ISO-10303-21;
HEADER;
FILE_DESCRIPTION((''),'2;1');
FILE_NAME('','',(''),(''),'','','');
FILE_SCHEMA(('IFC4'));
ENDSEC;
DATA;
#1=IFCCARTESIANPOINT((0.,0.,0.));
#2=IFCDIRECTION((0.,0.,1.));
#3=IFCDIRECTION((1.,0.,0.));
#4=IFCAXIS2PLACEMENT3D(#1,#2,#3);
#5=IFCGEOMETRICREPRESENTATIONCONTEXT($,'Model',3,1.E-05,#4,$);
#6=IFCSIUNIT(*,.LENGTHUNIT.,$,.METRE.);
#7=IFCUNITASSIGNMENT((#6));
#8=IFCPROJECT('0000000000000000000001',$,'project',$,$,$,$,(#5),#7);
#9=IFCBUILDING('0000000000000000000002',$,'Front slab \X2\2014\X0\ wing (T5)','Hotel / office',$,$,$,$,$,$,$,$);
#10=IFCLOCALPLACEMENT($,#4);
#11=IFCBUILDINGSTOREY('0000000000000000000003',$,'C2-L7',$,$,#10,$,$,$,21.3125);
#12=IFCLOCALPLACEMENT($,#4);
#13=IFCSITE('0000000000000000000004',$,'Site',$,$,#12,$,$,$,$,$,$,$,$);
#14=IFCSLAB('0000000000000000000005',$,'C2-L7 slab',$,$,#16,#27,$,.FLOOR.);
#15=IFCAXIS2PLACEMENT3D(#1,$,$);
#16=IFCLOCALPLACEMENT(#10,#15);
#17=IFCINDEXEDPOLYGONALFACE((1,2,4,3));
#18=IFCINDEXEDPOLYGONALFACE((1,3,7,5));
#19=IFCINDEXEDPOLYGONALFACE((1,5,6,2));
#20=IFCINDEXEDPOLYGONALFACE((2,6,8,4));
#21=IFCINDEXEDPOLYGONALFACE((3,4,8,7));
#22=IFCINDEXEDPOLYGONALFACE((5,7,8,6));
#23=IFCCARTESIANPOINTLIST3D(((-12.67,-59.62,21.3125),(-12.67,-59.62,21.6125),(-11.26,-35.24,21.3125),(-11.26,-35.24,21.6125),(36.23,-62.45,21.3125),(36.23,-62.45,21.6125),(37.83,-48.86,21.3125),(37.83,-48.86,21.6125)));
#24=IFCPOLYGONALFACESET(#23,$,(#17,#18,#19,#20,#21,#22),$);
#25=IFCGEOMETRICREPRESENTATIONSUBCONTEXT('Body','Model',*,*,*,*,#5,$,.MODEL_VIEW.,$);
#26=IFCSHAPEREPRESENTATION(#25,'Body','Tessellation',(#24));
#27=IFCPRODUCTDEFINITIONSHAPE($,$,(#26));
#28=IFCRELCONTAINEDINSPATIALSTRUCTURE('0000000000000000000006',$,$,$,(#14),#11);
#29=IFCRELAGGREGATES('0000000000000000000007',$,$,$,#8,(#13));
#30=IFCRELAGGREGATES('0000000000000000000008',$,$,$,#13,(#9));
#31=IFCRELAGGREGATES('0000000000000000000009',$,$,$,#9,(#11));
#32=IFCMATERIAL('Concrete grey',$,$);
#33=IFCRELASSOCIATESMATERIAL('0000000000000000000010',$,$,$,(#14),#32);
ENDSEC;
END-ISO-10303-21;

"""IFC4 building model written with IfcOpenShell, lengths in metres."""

from ifc_helpers import new_model, si_unit, frame, origin_with_axes, place, context, subcontext, project, spatial, polyline, outline, extrude, material, element, save


model = new_model("IFC4")

# Units and contexts
model_context = context("Model", 3, precision=1e-05, world=origin_with_axes())
body_context = subcontext(model_context, "Body", "Model", "MODEL_VIEW")
ifc_project = project(units=[si_unit("LENGTHUNIT", "METRE")], contexts=[model_context])

# Site, building, storey
site_placement = place(None, origin_with_axes())
site = spatial("IfcSite", under=ifc_project, at=site_placement, Name="Site")
building = spatial("IfcBuilding", under=site, Name="Front slab — wing (T5)", Description="Hotel / office")
storey_placement = place(None, origin_with_axes())
storey = spatial("IfcBuildingStorey", under=building, at=storey_placement, Name="C2-L7", Elevation=21.3125)

# Slab
ifc_material_1 = material(Name="Concrete grey")
slab_placement = place(storey_placement, origin_with_axes())
element("IfcSlab", 1, at=slab_placement, inside=storey, material=ifc_material_1, Name="C2-L7 slab", PredefinedType="FLOOR", context=body_context, shape_type="SweptSolid", body=[
    extrude(outline(polyline([(-11.26, -35.24), (-12.67, -59.62), (36.23, -62.45), (37.83, -48.86), (-11.26, -35.24)])), frame((0.0, 0.0, 21.3125), z_axis=(0.0, 0.0, 1.0), x_axis=(1.0, 0.0, 0.0)), (0.0, 0.0, 1.0), 0.3),
])

save(model, "model.ifc")
